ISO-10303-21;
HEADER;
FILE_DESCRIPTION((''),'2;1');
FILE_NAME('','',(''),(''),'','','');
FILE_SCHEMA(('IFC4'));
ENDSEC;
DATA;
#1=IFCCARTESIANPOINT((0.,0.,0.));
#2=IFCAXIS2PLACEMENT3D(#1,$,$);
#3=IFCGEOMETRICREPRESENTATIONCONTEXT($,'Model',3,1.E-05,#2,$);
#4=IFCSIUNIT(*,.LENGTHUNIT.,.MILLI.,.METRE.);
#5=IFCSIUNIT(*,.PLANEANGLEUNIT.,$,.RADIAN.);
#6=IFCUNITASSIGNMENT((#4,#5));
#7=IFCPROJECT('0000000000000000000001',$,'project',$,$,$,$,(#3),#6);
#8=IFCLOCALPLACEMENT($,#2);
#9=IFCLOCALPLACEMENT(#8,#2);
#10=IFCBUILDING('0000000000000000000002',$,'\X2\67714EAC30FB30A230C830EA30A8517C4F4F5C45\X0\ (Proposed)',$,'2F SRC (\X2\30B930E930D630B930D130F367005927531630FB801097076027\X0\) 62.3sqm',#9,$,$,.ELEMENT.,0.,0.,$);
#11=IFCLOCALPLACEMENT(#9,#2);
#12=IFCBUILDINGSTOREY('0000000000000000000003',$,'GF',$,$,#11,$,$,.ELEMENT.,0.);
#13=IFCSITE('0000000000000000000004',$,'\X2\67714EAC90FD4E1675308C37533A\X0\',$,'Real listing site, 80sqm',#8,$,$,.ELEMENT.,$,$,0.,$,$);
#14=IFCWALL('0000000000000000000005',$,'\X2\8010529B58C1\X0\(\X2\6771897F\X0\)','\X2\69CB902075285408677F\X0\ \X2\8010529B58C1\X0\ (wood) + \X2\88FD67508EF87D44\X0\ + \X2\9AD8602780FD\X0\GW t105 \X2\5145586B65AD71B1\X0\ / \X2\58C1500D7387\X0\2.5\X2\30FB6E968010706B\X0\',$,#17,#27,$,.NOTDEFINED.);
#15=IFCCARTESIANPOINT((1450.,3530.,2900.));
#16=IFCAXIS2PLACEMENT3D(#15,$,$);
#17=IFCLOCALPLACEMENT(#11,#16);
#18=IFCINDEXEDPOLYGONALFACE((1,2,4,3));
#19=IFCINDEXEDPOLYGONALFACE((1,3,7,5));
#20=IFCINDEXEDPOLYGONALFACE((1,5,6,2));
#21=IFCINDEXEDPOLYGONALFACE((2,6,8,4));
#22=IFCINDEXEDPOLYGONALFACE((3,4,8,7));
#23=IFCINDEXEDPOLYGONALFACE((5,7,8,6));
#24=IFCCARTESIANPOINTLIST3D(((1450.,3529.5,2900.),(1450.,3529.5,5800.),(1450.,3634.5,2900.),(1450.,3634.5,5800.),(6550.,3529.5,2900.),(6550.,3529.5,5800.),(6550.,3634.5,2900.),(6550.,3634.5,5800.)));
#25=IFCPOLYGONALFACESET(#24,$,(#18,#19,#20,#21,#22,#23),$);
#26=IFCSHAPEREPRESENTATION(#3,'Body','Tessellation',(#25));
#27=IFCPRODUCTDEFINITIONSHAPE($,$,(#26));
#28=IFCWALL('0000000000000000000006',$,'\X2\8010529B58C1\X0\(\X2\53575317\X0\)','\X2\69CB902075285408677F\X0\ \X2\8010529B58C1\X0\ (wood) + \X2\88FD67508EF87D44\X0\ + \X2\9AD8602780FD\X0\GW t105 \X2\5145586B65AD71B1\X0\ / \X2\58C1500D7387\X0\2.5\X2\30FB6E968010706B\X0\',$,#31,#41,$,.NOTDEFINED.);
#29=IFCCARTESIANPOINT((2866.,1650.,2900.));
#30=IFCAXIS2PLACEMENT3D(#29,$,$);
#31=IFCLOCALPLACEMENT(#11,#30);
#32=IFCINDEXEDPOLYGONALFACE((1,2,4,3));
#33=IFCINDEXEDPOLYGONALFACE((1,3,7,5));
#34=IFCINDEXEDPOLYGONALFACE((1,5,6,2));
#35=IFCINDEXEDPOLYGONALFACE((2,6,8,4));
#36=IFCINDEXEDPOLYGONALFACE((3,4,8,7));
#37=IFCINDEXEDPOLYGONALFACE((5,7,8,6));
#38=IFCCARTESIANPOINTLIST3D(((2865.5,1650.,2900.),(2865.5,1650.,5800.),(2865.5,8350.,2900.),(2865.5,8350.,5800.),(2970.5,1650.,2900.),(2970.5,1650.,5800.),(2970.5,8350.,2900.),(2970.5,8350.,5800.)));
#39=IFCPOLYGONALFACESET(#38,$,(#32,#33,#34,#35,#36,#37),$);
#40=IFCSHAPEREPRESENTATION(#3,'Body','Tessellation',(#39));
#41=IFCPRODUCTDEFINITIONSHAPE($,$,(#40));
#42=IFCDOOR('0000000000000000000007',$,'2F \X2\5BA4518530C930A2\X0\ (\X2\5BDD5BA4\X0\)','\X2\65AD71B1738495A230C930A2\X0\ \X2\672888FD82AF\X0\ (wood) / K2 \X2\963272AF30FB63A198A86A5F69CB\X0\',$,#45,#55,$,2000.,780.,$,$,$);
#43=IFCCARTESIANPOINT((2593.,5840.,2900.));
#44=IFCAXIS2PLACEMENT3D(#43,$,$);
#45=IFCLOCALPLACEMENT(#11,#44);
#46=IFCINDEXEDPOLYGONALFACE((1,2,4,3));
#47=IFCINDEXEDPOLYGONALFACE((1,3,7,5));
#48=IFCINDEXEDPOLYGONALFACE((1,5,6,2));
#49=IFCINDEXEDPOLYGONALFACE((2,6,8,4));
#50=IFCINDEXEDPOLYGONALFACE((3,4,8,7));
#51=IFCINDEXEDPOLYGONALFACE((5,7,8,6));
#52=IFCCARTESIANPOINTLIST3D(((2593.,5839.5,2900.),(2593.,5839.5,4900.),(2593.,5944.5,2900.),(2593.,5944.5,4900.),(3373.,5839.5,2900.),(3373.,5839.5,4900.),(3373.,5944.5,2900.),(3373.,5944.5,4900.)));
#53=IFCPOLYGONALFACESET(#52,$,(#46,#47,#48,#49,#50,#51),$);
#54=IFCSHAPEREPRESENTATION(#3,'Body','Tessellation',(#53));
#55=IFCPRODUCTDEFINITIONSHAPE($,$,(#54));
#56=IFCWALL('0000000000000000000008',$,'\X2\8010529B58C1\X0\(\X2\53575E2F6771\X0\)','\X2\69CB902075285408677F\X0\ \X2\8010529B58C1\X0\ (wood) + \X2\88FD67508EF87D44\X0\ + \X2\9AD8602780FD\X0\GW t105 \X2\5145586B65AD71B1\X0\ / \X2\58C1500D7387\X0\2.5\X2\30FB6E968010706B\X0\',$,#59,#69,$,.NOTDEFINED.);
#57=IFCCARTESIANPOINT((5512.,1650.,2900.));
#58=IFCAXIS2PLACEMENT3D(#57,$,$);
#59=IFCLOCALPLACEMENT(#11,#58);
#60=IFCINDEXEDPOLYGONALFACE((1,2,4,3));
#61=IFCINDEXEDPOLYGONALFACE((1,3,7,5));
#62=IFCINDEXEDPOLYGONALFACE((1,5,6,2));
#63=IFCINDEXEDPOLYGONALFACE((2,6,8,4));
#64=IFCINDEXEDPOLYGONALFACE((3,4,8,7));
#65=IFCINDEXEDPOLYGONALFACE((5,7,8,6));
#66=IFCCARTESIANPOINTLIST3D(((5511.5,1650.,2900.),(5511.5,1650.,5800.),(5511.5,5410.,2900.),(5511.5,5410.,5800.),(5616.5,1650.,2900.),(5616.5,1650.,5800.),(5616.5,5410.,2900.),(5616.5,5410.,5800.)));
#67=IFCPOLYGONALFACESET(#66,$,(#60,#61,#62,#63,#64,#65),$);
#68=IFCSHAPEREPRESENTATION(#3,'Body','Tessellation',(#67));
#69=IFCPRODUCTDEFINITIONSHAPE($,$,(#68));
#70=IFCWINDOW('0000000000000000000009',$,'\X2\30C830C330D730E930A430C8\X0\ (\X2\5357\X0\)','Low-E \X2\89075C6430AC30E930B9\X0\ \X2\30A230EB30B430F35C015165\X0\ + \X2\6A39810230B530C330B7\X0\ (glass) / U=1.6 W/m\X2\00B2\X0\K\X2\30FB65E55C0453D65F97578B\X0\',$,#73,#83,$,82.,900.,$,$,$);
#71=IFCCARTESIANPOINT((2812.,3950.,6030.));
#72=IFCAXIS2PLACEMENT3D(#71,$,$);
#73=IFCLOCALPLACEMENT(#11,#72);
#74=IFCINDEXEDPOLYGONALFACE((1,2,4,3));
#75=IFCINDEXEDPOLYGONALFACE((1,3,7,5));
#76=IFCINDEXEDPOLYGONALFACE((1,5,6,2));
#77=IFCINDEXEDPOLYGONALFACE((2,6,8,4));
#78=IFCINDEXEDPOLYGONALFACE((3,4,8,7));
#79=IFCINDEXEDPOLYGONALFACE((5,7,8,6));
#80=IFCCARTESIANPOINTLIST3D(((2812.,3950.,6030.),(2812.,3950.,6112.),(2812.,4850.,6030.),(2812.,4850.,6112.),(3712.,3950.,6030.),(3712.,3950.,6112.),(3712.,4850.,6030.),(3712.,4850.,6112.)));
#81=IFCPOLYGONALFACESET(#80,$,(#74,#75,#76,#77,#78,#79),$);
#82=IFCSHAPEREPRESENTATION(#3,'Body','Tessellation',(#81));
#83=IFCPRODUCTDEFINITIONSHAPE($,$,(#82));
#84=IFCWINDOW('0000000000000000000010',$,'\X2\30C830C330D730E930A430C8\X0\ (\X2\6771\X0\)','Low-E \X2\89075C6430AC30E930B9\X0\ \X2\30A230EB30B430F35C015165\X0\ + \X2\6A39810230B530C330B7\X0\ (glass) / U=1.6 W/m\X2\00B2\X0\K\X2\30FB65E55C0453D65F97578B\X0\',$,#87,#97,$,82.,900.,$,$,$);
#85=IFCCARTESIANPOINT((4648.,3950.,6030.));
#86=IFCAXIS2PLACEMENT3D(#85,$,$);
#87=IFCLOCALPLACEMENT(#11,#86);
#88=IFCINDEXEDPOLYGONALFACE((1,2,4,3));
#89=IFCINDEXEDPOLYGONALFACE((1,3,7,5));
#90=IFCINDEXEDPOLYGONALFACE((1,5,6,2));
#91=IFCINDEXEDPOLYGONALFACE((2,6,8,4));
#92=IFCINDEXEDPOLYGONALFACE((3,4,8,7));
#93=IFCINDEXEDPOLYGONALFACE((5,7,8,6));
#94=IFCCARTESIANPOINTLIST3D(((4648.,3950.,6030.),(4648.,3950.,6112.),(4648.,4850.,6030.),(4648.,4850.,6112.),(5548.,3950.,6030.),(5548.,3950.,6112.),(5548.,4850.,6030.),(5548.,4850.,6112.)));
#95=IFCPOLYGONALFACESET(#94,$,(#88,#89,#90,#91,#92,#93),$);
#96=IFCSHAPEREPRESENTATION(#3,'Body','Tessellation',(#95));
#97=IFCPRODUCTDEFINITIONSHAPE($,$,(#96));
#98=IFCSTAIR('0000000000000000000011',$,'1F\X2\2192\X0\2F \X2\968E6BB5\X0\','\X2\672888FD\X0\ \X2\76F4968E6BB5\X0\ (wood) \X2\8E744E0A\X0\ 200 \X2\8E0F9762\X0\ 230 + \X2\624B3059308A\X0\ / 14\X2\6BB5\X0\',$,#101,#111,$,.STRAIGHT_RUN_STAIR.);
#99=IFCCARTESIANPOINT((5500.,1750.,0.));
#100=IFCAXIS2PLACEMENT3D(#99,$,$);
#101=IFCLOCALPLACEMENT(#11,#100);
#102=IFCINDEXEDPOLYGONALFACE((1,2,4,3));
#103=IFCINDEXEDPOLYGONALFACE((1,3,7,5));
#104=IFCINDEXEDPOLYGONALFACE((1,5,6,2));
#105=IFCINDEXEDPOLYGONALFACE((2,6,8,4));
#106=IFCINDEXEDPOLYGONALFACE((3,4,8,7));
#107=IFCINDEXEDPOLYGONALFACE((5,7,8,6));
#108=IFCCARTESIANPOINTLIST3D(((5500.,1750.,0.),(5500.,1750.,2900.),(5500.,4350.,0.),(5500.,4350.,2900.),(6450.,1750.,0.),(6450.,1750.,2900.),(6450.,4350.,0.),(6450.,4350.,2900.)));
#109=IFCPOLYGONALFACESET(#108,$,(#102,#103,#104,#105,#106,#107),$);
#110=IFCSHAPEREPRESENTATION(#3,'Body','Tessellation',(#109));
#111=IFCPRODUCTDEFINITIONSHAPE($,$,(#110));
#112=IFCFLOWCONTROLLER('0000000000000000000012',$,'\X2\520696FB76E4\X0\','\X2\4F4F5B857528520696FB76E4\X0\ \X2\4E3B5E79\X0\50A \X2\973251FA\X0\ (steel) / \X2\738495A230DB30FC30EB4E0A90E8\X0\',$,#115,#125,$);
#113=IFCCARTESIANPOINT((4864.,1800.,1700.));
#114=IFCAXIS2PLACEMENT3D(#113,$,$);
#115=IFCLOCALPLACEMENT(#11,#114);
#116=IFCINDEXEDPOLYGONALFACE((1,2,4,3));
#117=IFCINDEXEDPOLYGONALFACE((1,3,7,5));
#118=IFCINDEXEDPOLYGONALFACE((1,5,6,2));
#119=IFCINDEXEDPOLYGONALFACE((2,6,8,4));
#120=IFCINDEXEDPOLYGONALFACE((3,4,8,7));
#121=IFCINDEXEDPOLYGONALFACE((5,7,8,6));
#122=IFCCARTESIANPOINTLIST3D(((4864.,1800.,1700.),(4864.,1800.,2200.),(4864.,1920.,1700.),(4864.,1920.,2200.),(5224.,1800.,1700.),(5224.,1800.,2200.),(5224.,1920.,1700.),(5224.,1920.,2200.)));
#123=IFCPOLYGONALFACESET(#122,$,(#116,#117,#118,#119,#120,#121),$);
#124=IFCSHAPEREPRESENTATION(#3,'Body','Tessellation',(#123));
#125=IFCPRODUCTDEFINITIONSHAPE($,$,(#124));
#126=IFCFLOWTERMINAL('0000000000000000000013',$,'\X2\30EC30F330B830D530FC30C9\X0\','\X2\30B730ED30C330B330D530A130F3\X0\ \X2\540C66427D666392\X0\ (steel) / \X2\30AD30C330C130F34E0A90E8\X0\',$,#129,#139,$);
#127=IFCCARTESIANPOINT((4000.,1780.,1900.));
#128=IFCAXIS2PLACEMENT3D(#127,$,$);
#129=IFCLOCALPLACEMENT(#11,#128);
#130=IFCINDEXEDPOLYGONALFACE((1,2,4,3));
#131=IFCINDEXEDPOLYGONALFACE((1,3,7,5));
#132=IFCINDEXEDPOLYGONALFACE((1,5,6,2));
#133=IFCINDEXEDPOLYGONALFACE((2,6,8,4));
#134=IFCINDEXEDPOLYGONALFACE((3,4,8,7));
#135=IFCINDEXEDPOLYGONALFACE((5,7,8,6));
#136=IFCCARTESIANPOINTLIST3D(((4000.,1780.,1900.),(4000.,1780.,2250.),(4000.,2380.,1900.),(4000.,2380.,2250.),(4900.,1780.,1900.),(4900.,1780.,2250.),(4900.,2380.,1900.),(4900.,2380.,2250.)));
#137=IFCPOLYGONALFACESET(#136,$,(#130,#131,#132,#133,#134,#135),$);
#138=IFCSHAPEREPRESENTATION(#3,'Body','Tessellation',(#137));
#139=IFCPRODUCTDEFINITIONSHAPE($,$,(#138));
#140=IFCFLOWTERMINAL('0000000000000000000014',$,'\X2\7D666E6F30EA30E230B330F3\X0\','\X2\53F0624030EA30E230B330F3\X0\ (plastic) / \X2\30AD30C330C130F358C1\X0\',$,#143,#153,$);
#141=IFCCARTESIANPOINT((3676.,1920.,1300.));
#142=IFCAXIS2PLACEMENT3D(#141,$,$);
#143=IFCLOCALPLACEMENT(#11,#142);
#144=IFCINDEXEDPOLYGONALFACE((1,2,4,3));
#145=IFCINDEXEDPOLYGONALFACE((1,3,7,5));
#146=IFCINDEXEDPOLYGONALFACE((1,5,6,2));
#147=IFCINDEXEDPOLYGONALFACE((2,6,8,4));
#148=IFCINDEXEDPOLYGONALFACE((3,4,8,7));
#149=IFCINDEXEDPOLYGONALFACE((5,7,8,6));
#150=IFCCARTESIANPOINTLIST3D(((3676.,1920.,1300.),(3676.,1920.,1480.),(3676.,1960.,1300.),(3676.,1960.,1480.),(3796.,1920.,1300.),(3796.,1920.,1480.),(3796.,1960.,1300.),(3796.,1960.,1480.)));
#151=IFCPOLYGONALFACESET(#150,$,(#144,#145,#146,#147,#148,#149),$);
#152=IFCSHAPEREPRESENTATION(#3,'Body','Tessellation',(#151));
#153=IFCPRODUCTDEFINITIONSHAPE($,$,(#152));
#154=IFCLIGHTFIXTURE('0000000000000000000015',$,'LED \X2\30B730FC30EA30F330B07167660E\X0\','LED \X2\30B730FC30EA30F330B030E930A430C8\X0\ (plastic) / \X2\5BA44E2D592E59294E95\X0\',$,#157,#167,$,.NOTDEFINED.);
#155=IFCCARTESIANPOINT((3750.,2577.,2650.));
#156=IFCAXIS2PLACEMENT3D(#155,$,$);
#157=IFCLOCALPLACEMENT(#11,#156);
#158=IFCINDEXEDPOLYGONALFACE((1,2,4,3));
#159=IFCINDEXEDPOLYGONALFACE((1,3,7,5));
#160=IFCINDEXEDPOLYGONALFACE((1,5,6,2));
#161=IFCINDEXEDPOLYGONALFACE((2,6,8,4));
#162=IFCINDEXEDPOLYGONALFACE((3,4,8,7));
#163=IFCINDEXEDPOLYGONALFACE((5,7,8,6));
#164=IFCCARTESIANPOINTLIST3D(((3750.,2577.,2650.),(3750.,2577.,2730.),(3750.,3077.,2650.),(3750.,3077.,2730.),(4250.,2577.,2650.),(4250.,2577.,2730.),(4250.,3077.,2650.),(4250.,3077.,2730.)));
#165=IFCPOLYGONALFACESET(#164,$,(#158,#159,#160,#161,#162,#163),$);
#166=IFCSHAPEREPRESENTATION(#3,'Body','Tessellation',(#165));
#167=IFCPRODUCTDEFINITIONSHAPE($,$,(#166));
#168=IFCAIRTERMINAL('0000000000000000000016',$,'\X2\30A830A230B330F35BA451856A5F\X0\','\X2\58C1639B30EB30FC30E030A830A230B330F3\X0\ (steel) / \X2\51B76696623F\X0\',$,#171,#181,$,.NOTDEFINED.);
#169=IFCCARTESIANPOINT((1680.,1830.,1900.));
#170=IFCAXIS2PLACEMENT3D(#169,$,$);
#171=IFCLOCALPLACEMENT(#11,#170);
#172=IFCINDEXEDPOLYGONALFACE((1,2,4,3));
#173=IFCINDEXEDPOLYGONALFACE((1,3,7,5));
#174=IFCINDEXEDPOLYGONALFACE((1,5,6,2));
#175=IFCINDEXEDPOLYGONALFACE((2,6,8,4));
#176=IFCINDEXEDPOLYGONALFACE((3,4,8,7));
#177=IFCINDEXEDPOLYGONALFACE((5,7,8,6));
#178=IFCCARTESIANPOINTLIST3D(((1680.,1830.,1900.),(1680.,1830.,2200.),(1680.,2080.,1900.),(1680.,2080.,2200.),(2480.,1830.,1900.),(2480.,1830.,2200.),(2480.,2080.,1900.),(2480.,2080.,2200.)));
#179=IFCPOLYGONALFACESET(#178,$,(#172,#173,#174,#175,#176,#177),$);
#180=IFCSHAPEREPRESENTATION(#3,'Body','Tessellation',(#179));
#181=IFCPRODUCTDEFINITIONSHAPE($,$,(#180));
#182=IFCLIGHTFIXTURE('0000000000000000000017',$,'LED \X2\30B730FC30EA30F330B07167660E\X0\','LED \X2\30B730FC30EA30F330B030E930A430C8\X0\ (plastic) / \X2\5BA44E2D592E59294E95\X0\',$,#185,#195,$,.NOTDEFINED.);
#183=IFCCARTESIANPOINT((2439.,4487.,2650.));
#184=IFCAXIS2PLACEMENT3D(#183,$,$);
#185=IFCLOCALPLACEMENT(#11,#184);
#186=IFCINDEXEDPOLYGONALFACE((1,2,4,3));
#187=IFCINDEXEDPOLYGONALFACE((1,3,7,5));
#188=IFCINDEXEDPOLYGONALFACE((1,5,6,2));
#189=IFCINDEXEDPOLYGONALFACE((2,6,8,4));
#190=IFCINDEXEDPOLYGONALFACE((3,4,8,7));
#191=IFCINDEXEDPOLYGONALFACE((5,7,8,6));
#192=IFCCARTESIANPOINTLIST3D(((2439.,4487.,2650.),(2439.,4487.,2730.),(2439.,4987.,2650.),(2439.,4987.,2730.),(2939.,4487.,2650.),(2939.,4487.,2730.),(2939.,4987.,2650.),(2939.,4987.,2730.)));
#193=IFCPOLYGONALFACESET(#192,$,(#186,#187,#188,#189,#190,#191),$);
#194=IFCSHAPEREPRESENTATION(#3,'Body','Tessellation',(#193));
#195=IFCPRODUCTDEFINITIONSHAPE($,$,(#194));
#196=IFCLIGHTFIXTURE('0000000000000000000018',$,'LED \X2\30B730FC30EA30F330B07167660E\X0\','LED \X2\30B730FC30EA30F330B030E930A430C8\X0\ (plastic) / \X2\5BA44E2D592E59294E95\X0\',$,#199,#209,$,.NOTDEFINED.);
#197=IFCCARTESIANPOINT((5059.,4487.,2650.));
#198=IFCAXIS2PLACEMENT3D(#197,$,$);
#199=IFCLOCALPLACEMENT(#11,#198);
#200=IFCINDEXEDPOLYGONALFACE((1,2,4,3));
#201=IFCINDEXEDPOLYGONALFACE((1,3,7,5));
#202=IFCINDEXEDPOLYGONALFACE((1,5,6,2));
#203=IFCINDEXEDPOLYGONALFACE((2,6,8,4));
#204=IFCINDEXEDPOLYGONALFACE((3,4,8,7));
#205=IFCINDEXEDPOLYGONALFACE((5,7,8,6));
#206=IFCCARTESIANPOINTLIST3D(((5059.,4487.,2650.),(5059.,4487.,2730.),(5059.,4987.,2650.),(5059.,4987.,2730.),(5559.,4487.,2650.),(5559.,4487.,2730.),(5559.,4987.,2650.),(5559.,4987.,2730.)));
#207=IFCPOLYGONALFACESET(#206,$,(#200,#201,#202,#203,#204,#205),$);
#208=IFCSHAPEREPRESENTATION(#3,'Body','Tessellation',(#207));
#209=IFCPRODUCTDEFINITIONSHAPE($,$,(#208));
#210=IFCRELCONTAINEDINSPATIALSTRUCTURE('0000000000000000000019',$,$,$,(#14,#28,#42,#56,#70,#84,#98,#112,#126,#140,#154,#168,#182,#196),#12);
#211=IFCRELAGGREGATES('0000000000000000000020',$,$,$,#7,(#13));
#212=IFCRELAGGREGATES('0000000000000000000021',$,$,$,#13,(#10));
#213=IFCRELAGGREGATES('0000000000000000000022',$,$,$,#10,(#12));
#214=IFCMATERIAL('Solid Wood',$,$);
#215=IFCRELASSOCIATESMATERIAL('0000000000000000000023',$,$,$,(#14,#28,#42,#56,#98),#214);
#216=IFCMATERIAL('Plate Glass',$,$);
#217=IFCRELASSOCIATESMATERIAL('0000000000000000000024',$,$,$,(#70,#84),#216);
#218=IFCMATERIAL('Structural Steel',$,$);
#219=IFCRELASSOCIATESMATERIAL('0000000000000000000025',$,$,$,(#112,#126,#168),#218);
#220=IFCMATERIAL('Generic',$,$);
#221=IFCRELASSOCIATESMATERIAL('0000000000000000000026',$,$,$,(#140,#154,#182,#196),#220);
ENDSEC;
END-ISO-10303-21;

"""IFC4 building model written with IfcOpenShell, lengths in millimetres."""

from ifc_helpers import new_model, si_unit, frame, frame_2d, origin, place, context, project, spatial, rectangle, extrude, material, element, fill, save


model = new_model("IFC4")

# Units and contexts
model_context = context("Model", 3, precision=1e-05, world=origin())
ifc_project = project(units=[si_unit("LENGTHUNIT", "METRE", prefix="MILLI"), si_unit("PLANEANGLEUNIT", "RADIAN")], contexts=[model_context])

# Site, building, storey
site_placement = place(None, origin())
site = spatial("IfcSite", under=ifc_project, at=site_placement, Name="東京都世田谷区", ObjectType="Real listing site, 80sqm", CompositionType="ELEMENT", RefElevation=0.0)
building_placement = place(site_placement, origin())
building = spatial("IfcBuilding", under=site, at=building_placement, Name="東京・アトリエ兼住居 (Proposed)", ObjectType="2F SRC (スラブスパン最大化・耐震性) 62.3sqm", CompositionType="ELEMENT", ElevationOfRefHeight=0.0, ElevationOfTerrain=0.0)
storey_placement = place(building_placement, origin())
storey = spatial("IfcBuildingStorey", under=building, at=storey_placement, Name="GF", CompositionType="ELEMENT", Elevation=0.0)

# Shared definitions
ifc_material_1 = material(Name="Solid Wood")

# Wall
wall_1_placement = place(storey_placement, frame((1450.0, 3530.0, 2900.0)))
element("IfcWall", 1, at=wall_1_placement, inside=storey, material=ifc_material_1, Name="耐力壁(東西)", Description="構造用合板 耐力壁 (wood) + 製材軸組 + 高性能GW t105 充填断熱 / 壁倍率2.5・準耐火", PredefinedType="NOTDEFINED", context=model_context, shape_type="SweptSolid", body=[
    extrude(rectangle(XDim=5100.0, YDim=105.0, at=frame_2d((2550.0, 52.0))), frame((1450.0, 3530.0, 2900.0)), (0.0, 0.0, 1.0), 2900.0),
])

# Wall, opening, door
wall_2_placement = place(storey_placement, frame((2866.0, 1650.0, 2900.0)))
wall_2 = element("IfcWall", 2, at=wall_2_placement, inside=storey, material=ifc_material_1, Name="耐力壁(南北)", Description="構造用合板 耐力壁 (wood) + 製材軸組 + 高性能GW t105 充填断熱 / 壁倍率2.5・準耐火", PredefinedType="NOTDEFINED", context=model_context, shape_type="SweptSolid", body=[
    extrude(rectangle(XDim=105.0, YDim=6700.0, at=frame_2d((52.0, 3350.0))), frame((2866.0, 1650.0, 2900.0)), (0.0, 0.0, 1.0), 2900.0),
])
opening_placement = place(storey_placement, frame((2593.0, 5840.0, 2900.0)))
opening = element("IfcOpeningElement", 3, at=opening_placement, cuts=wall_2, PredefinedType="NOTDEFINED", context=model_context, shape_type="SweptSolid", body=[
    extrude(rectangle(XDim=780.0, YDim=105.0, at=frame_2d((390.0, 52.0))), frame((2593.0, 5840.0, 2900.0)), (0.0, 0.0, 1.0), 2000.0),
])
door_placement = place(storey_placement, frame((2593.0, 5840.0, 2900.0)))
door = element("IfcDoor", 4, at=door_placement, inside=storey, material=ifc_material_1, Name="2F 室内ドア (寝室)", Description="断熱玄関ドア 木製芯 (wood) / K2 防犯・採風機構", OverallHeight=2000.0, OverallWidth=780.0, context=model_context, shape_type="SweptSolid", body=[
    extrude(rectangle(XDim=780.0, YDim=105.0, at=frame_2d((390.0, 52.0))), frame((2593.0, 5840.0, 2900.0)), (0.0, 0.0, 1.0), 2000.0),
])
fill(opening, door)

# Wall
wall_3_placement = place(storey_placement, frame((5512.0, 1650.0, 2900.0)))
element("IfcWall", 5, at=wall_3_placement, inside=storey, material=ifc_material_1, Name="耐力壁(南帯東)", Description="構造用合板 耐力壁 (wood) + 製材軸組 + 高性能GW t105 充填断熱 / 壁倍率2.5・準耐火", PredefinedType="NOTDEFINED", context=model_context, shape_type="SweptSolid", body=[
    extrude(rectangle(XDim=105.0, YDim=3760.0, at=frame_2d((52.0, 1880.0))), frame((5512.0, 1650.0, 2900.0)), (0.0, 0.0, 1.0), 2900.0),
])

# Windows
ifc_material_2 = material(Name="Plate Glass")
window_1_placement = place(storey_placement, frame((2812.0, 3950.0, 6030.0)))
element("IfcWindow", 6, at=window_1_placement, inside=storey, material=ifc_material_2, Name="トップライト (南)", Description="Low-E 複層ガラス アルゴン封入 + 樹脂サッシ (glass) / U=1.6 W/m²K・日射取得型", OverallHeight=82.0, OverallWidth=900.0, context=model_context, shape_type="SweptSolid", body=[
    extrude(rectangle(XDim=900.0, YDim=900.0, at=frame_2d((450.0, 450.0))), frame((2812.0, 3950.0, 6030.0)), (0.0, 0.0, 1.0), 82.0),
])
window_2_placement = place(storey_placement, frame((4648.0, 3950.0, 6030.0)))
element("IfcWindow", 7, at=window_2_placement, inside=storey, material=ifc_material_2, Name="トップライト (東)", Description="Low-E 複層ガラス アルゴン封入 + 樹脂サッシ (glass) / U=1.6 W/m²K・日射取得型", OverallHeight=82.0, OverallWidth=900.0, context=model_context, shape_type="SweptSolid", body=[
    extrude(rectangle(XDim=900.0, YDim=900.0, at=frame_2d((450.0, 450.0))), frame((4648.0, 3950.0, 6030.0)), (0.0, 0.0, 1.0), 82.0),
])

# Stair
stair_placement = place(storey_placement, frame((5500.0, 1750.0, 0.0)))
element("IfcStair", 8, at=stair_placement, inside=storey, material=ifc_material_1, Name="1F→2F 階段", Description="木製 直階段 (wood) 蹴上 200 踏面 230 + 手すり / 14段", PredefinedType="STRAIGHT_RUN_STAIR", context=model_context, shape_type="SweptSolid", body=[
    extrude(rectangle(XDim=950.0, YDim=2600.0, at=frame_2d((475.0, 1300.0))), frame((5500.0, 1750.0, 0.0)), (0.0, 0.0, 1.0), 2900.0),
])

# Shared definitions
ifc_material_3 = material(Name="Structural Steel")

# Flow controller
flow_controller_placement = place(storey_placement, frame((4864.0, 1800.0, 1700.0)))
element("IfcFlowController", 9, at=flow_controller_placement, inside=storey, material=ifc_material_3, Name="分電盤", Description="住宅用分電盤 主幹50A 露出 (steel) / 玄関ホール上部", context=model_context, shape_type="SweptSolid", body=[
    extrude(rectangle(XDim=360.0, YDim=120.0, at=frame_2d((180.0, 60.0))), frame((4864.0, 1800.0, 1700.0)), (0.0, 0.0, 1.0), 500.0),
])

# Flow terminals
flow_terminal_1_placement = place(storey_placement, frame((4000.0, 1780.0, 1900.0)))
element("IfcFlowTerminal", 10, at=flow_terminal_1_placement, inside=storey, material=ifc_material_3, Name="レンジフード", Description="シロッコファン 同時給排 (steel) / キッチン上部", context=model_context, shape_type="SweptSolid", body=[
    extrude(rectangle(XDim=900.0, YDim=600.0, at=frame_2d((450.0, 300.0))), frame((4000.0, 1780.0, 1900.0)), (0.0, 0.0, 1.0), 350.0),
])
ifc_material_4 = material(Name="Generic")
flow_terminal_2_placement = place(storey_placement, frame((3676.0, 1920.0, 1300.0)))
element("IfcFlowTerminal", 11, at=flow_terminal_2_placement, inside=storey, material=ifc_material_4, Name="給湯リモコン", Description="台所リモコン (plastic) / キッチン壁", context=model_context, shape_type="SweptSolid", body=[
    extrude(rectangle(XDim=120.0, YDim=40.0, at=frame_2d((60.0, 20.0))), frame((3676.0, 1920.0, 1300.0)), (0.0, 0.0, 1.0), 180.0),
])

# Light fixture
light_fixture_1_placement = place(storey_placement, frame((3750.0, 2577.0, 2650.0)))
element("IfcLightFixture", 12, at=light_fixture_1_placement, inside=storey, material=ifc_material_4, Name="LED シーリング照明", Description="LED シーリングライト (plastic) / 室中央天井", PredefinedType="NOTDEFINED", context=model_context, shape_type="SweptSolid", body=[
    extrude(rectangle(XDim=500.0, YDim=500.0, at=frame_2d((250.0, 250.0))), frame((3750.0, 2577.0, 2650.0)), (0.0, 0.0, 1.0), 80.0),
])

# Air terminal
air_terminal_1_placement = place(storey_placement, frame((1680.0, 1830.0, 1900.0)))
element("IfcAirTerminal", 13, at=air_terminal_1_placement, inside=storey, material=ifc_material_3, Name="エアコン室内機", Description="壁掛ルームエアコン (steel) / 冷暖房", PredefinedType="NOTDEFINED", context=model_context, shape_type="SweptSolid", body=[
    extrude(rectangle(XDim=800.0, YDim=250.0, at=frame_2d((400.0, 125.0))), frame((1680.0, 1830.0, 1900.0)), (0.0, 0.0, 1.0), 300.0),
])

# Light fixtures
light_fixture_2_placement = place(storey_placement, frame((2439.0, 4487.0, 2650.0)))
element("IfcLightFixture", 14, at=light_fixture_2_placement, inside=storey, material=ifc_material_4, Name="LED シーリング照明", Description="LED シーリングライト (plastic) / 室中央天井", PredefinedType="NOTDEFINED", context=model_context, shape_type="SweptSolid", body=[
    extrude(rectangle(XDim=500.0, YDim=500.0, at=frame_2d((250.0, 250.0))), frame((2439.0, 4487.0, 2650.0)), (0.0, 0.0, 1.0), 80.0),
])
light_fixture_3_placement = place(storey_placement, frame((5059.0, 4487.0, 2650.0)))
element("IfcLightFixture", 15, at=light_fixture_3_placement, inside=storey, material=ifc_material_4, Name="LED シーリング照明", Description="LED シーリングライト (plastic) / 室中央天井", PredefinedType="NOTDEFINED", context=model_context, shape_type="SweptSolid", body=[
    extrude(rectangle(XDim=500.0, YDim=500.0, at=frame_2d((250.0, 250.0))), frame((5059.0, 4487.0, 2650.0)), (0.0, 0.0, 1.0), 80.0),
])

save(model, "model.ifc")
